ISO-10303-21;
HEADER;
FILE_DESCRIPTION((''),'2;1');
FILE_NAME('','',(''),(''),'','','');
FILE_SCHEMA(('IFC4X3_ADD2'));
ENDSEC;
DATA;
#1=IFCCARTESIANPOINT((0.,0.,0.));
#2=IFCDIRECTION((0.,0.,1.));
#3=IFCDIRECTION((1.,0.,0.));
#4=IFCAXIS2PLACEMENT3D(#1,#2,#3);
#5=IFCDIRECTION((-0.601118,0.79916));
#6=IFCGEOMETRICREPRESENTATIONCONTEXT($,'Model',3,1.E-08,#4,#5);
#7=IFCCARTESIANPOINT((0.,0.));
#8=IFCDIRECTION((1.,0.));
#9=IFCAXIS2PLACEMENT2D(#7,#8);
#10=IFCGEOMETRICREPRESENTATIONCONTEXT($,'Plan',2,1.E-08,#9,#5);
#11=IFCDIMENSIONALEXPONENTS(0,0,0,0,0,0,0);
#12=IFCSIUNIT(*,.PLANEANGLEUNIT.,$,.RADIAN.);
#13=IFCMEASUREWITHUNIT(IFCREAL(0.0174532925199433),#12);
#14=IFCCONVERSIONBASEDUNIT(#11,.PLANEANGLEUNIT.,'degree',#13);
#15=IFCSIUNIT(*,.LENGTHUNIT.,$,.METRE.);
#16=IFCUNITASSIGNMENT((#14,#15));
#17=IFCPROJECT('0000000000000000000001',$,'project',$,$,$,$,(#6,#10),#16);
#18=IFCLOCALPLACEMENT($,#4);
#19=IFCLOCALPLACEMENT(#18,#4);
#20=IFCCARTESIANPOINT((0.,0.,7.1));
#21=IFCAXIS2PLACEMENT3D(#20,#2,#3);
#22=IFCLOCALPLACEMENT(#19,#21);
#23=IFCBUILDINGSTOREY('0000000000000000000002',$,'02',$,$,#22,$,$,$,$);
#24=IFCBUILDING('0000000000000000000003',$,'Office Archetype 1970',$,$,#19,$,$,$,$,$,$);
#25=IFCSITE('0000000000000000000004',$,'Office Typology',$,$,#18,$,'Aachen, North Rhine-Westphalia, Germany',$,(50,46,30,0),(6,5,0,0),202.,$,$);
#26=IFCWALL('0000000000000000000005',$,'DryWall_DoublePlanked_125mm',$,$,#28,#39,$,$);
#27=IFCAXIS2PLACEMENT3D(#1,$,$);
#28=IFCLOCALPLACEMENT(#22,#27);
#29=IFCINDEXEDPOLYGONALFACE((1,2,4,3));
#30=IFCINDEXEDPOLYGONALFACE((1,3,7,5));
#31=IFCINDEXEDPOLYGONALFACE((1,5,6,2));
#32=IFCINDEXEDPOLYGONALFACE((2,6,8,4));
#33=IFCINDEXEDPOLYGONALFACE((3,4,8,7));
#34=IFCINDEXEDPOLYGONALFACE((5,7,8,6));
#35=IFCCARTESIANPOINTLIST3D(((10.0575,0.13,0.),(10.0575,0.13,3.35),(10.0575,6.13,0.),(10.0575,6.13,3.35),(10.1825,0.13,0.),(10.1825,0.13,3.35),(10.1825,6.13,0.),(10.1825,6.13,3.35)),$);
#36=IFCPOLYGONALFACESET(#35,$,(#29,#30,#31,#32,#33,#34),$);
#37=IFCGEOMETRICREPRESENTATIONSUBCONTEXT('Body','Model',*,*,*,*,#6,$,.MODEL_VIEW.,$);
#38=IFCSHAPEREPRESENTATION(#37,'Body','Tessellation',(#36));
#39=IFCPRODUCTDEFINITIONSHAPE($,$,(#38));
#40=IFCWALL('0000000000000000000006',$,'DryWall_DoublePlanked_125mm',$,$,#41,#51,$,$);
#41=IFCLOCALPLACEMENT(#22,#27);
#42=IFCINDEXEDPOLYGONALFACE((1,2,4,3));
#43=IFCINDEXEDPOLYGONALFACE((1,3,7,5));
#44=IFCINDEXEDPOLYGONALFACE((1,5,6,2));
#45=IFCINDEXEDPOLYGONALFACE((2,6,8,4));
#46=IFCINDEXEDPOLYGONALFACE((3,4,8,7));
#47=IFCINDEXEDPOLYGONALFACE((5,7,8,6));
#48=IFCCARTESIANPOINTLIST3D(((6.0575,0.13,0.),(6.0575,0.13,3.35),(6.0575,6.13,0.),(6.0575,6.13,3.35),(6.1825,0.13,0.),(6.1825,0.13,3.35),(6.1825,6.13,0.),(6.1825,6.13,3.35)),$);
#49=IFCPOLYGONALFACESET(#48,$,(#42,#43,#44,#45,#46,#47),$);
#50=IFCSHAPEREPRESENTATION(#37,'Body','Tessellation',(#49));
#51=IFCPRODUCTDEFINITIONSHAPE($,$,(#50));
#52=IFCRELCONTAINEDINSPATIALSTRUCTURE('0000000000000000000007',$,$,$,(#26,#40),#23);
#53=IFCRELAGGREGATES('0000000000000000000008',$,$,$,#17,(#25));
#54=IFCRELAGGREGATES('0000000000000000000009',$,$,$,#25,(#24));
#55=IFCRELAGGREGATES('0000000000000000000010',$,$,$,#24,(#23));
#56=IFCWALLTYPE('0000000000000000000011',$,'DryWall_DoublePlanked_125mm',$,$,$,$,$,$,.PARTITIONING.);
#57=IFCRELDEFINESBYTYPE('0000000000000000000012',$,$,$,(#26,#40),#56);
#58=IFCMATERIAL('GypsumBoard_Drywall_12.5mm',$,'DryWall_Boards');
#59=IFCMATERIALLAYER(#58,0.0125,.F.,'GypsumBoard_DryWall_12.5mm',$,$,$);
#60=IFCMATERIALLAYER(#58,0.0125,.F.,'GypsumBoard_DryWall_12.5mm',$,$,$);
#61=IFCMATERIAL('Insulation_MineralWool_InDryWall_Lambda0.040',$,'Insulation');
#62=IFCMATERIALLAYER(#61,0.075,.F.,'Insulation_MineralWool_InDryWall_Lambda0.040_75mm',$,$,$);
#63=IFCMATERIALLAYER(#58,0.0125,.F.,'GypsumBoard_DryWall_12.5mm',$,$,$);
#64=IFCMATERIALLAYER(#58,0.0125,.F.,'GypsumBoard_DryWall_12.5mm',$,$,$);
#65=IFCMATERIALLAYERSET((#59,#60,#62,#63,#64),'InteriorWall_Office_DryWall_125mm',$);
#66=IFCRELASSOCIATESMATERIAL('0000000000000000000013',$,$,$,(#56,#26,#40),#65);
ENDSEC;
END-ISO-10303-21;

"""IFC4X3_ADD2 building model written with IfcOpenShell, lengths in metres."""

from ifc_helpers import new_model, entity, si_unit, converted_unit, direction, frame, origin_with_axes, origin_2d_with_axis, place, context, subcontext, project, spatial, line, indexed_curve, outline, extrude, material, layer, layer_set, layer_usage, type_object, element, save


model = new_model("IFC4X3_ADD2")

# Units and contexts
model_context = context("Model", 3, precision=1e-08, world=origin_with_axes(), true_north=direction((-0.601118, 0.79916)))
plan_context = context("Plan", 2, precision=1e-08, world=origin_2d_with_axis(), true_north=direction((-0.601118, 0.79916)))
body_context = subcontext(model_context, "Body", "Model", "MODEL_VIEW")
ifc_project = project(units=[converted_unit("PLANEANGLEUNIT", "degree", entity("IfcReal", 0.0174532925199433), si_unit("PLANEANGLEUNIT", "RADIAN"), dimensions=[0, 0, 0, 0, 0, 0, 0]), si_unit("LENGTHUNIT", "METRE")], contexts=[model_context, plan_context])

# Site, building, storey
site_placement = place(None, origin_with_axes())
site = spatial("IfcSite", under=ifc_project, at=site_placement, Name="Office Typology", LongName="Aachen, North Rhine-Westphalia, Germany", RefLatitude=(50, 46, 30, 0), RefLongitude=(6, 5, 0, 0), RefElevation=202.0)
building_placement = place(site_placement, origin_with_axes())
building = spatial("IfcBuilding", under=site, at=building_placement, Name="Office Archetype 1970")
storey_placement = place(building_placement, frame((0.0, 0.0, 7.1), z_axis=(0.0, 0.0, 1.0), x_axis=(1.0, 0.0, 0.0)))
storey = spatial("IfcBuildingStorey", under=building, at=storey_placement, Name="02")

# Walls
ifc_material_1 = material(Name="GypsumBoard_Drywall_12.5mm", Category="DryWall_Boards")
ifc_layer_1 = layer(ifc_material_1, 0.0125, ventilated=False, Name="GypsumBoard_DryWall_12.5mm")
ifc_layer_2 = layer(ifc_material_1, 0.0125, ventilated=False, Name="GypsumBoard_DryWall_12.5mm")
ifc_material_2 = material(Name="Insulation_MineralWool_InDryWall_Lambda0.040", Category="Insulation")
ifc_layer_3 = layer(ifc_material_2, 0.075, ventilated=False, Name="Insulation_MineralWool_InDryWall_Lambda0.040_75mm")
ifc_layer_4 = layer(ifc_material_1, 0.0125, ventilated=False, Name="GypsumBoard_DryWall_12.5mm")
ifc_layer_5 = layer(ifc_material_1, 0.0125, ventilated=False, Name="GypsumBoard_DryWall_12.5mm")
ifc_layer_set_1 = layer_set([ifc_layer_1, ifc_layer_2, ifc_layer_3, ifc_layer_4, ifc_layer_5], Name="InteriorWall_Office_DryWall_125mm")
ifc_layer_usage_1 = layer_usage(ifc_layer_set_1, "AXIS2", "POSITIVE", 0.0)
wall_type_1 = type_object("IfcWallType", Name="DryWall_DoublePlanked_125mm", PredefinedType="PARTITIONING", material=ifc_layer_set_1)
wall_1_placement = place(storey_placement, frame((10.0575, 6.13, 0.0), z_axis=(0.0, 0.0, 1.0), x_axis=(0.0, -1.0, 0.0)))
element("IfcWall", 1, at=wall_1_placement, inside=storey, type_object=wall_type_1, material=ifc_layer_usage_1, Name="DryWall_DoublePlanked_125mm", context=body_context, shape_type="SweptSolid", body=[
    extrude(outline(indexed_curve([(0.0, 0.0), (0.0, 0.125), (6.0, 0.125), (6.0, 0.0)], segments=[line(1, 2, 3, 4, 1)])), origin_with_axes(), (0.0, 0.0, 1.0), 3.35),
])
ifc_layer_usage_2 = layer_usage(ifc_layer_set_1, "AXIS2", "POSITIVE", 0.0)
wall_2_placement = place(storey_placement, frame((6.0575, 6.13, 0.0), z_axis=(0.0, 0.0, 1.0), x_axis=(0.0, -1.0, 0.0)))
element("IfcWall", 2, at=wall_2_placement, inside=storey, type_object=wall_type_1, material=ifc_layer_usage_2, Name="DryWall_DoublePlanked_125mm", context=body_context, shape_type="SweptSolid", body=[
    extrude(outline(indexed_curve([(0.0, 0.0), (0.0, 0.125), (6.0, 0.125), (6.0, 0.0)], segments=[line(1, 2, 3, 4, 1)])), origin_with_axes(), (0.0, 0.0, 1.0), 3.35),
])

save(model, "model.ifc")
